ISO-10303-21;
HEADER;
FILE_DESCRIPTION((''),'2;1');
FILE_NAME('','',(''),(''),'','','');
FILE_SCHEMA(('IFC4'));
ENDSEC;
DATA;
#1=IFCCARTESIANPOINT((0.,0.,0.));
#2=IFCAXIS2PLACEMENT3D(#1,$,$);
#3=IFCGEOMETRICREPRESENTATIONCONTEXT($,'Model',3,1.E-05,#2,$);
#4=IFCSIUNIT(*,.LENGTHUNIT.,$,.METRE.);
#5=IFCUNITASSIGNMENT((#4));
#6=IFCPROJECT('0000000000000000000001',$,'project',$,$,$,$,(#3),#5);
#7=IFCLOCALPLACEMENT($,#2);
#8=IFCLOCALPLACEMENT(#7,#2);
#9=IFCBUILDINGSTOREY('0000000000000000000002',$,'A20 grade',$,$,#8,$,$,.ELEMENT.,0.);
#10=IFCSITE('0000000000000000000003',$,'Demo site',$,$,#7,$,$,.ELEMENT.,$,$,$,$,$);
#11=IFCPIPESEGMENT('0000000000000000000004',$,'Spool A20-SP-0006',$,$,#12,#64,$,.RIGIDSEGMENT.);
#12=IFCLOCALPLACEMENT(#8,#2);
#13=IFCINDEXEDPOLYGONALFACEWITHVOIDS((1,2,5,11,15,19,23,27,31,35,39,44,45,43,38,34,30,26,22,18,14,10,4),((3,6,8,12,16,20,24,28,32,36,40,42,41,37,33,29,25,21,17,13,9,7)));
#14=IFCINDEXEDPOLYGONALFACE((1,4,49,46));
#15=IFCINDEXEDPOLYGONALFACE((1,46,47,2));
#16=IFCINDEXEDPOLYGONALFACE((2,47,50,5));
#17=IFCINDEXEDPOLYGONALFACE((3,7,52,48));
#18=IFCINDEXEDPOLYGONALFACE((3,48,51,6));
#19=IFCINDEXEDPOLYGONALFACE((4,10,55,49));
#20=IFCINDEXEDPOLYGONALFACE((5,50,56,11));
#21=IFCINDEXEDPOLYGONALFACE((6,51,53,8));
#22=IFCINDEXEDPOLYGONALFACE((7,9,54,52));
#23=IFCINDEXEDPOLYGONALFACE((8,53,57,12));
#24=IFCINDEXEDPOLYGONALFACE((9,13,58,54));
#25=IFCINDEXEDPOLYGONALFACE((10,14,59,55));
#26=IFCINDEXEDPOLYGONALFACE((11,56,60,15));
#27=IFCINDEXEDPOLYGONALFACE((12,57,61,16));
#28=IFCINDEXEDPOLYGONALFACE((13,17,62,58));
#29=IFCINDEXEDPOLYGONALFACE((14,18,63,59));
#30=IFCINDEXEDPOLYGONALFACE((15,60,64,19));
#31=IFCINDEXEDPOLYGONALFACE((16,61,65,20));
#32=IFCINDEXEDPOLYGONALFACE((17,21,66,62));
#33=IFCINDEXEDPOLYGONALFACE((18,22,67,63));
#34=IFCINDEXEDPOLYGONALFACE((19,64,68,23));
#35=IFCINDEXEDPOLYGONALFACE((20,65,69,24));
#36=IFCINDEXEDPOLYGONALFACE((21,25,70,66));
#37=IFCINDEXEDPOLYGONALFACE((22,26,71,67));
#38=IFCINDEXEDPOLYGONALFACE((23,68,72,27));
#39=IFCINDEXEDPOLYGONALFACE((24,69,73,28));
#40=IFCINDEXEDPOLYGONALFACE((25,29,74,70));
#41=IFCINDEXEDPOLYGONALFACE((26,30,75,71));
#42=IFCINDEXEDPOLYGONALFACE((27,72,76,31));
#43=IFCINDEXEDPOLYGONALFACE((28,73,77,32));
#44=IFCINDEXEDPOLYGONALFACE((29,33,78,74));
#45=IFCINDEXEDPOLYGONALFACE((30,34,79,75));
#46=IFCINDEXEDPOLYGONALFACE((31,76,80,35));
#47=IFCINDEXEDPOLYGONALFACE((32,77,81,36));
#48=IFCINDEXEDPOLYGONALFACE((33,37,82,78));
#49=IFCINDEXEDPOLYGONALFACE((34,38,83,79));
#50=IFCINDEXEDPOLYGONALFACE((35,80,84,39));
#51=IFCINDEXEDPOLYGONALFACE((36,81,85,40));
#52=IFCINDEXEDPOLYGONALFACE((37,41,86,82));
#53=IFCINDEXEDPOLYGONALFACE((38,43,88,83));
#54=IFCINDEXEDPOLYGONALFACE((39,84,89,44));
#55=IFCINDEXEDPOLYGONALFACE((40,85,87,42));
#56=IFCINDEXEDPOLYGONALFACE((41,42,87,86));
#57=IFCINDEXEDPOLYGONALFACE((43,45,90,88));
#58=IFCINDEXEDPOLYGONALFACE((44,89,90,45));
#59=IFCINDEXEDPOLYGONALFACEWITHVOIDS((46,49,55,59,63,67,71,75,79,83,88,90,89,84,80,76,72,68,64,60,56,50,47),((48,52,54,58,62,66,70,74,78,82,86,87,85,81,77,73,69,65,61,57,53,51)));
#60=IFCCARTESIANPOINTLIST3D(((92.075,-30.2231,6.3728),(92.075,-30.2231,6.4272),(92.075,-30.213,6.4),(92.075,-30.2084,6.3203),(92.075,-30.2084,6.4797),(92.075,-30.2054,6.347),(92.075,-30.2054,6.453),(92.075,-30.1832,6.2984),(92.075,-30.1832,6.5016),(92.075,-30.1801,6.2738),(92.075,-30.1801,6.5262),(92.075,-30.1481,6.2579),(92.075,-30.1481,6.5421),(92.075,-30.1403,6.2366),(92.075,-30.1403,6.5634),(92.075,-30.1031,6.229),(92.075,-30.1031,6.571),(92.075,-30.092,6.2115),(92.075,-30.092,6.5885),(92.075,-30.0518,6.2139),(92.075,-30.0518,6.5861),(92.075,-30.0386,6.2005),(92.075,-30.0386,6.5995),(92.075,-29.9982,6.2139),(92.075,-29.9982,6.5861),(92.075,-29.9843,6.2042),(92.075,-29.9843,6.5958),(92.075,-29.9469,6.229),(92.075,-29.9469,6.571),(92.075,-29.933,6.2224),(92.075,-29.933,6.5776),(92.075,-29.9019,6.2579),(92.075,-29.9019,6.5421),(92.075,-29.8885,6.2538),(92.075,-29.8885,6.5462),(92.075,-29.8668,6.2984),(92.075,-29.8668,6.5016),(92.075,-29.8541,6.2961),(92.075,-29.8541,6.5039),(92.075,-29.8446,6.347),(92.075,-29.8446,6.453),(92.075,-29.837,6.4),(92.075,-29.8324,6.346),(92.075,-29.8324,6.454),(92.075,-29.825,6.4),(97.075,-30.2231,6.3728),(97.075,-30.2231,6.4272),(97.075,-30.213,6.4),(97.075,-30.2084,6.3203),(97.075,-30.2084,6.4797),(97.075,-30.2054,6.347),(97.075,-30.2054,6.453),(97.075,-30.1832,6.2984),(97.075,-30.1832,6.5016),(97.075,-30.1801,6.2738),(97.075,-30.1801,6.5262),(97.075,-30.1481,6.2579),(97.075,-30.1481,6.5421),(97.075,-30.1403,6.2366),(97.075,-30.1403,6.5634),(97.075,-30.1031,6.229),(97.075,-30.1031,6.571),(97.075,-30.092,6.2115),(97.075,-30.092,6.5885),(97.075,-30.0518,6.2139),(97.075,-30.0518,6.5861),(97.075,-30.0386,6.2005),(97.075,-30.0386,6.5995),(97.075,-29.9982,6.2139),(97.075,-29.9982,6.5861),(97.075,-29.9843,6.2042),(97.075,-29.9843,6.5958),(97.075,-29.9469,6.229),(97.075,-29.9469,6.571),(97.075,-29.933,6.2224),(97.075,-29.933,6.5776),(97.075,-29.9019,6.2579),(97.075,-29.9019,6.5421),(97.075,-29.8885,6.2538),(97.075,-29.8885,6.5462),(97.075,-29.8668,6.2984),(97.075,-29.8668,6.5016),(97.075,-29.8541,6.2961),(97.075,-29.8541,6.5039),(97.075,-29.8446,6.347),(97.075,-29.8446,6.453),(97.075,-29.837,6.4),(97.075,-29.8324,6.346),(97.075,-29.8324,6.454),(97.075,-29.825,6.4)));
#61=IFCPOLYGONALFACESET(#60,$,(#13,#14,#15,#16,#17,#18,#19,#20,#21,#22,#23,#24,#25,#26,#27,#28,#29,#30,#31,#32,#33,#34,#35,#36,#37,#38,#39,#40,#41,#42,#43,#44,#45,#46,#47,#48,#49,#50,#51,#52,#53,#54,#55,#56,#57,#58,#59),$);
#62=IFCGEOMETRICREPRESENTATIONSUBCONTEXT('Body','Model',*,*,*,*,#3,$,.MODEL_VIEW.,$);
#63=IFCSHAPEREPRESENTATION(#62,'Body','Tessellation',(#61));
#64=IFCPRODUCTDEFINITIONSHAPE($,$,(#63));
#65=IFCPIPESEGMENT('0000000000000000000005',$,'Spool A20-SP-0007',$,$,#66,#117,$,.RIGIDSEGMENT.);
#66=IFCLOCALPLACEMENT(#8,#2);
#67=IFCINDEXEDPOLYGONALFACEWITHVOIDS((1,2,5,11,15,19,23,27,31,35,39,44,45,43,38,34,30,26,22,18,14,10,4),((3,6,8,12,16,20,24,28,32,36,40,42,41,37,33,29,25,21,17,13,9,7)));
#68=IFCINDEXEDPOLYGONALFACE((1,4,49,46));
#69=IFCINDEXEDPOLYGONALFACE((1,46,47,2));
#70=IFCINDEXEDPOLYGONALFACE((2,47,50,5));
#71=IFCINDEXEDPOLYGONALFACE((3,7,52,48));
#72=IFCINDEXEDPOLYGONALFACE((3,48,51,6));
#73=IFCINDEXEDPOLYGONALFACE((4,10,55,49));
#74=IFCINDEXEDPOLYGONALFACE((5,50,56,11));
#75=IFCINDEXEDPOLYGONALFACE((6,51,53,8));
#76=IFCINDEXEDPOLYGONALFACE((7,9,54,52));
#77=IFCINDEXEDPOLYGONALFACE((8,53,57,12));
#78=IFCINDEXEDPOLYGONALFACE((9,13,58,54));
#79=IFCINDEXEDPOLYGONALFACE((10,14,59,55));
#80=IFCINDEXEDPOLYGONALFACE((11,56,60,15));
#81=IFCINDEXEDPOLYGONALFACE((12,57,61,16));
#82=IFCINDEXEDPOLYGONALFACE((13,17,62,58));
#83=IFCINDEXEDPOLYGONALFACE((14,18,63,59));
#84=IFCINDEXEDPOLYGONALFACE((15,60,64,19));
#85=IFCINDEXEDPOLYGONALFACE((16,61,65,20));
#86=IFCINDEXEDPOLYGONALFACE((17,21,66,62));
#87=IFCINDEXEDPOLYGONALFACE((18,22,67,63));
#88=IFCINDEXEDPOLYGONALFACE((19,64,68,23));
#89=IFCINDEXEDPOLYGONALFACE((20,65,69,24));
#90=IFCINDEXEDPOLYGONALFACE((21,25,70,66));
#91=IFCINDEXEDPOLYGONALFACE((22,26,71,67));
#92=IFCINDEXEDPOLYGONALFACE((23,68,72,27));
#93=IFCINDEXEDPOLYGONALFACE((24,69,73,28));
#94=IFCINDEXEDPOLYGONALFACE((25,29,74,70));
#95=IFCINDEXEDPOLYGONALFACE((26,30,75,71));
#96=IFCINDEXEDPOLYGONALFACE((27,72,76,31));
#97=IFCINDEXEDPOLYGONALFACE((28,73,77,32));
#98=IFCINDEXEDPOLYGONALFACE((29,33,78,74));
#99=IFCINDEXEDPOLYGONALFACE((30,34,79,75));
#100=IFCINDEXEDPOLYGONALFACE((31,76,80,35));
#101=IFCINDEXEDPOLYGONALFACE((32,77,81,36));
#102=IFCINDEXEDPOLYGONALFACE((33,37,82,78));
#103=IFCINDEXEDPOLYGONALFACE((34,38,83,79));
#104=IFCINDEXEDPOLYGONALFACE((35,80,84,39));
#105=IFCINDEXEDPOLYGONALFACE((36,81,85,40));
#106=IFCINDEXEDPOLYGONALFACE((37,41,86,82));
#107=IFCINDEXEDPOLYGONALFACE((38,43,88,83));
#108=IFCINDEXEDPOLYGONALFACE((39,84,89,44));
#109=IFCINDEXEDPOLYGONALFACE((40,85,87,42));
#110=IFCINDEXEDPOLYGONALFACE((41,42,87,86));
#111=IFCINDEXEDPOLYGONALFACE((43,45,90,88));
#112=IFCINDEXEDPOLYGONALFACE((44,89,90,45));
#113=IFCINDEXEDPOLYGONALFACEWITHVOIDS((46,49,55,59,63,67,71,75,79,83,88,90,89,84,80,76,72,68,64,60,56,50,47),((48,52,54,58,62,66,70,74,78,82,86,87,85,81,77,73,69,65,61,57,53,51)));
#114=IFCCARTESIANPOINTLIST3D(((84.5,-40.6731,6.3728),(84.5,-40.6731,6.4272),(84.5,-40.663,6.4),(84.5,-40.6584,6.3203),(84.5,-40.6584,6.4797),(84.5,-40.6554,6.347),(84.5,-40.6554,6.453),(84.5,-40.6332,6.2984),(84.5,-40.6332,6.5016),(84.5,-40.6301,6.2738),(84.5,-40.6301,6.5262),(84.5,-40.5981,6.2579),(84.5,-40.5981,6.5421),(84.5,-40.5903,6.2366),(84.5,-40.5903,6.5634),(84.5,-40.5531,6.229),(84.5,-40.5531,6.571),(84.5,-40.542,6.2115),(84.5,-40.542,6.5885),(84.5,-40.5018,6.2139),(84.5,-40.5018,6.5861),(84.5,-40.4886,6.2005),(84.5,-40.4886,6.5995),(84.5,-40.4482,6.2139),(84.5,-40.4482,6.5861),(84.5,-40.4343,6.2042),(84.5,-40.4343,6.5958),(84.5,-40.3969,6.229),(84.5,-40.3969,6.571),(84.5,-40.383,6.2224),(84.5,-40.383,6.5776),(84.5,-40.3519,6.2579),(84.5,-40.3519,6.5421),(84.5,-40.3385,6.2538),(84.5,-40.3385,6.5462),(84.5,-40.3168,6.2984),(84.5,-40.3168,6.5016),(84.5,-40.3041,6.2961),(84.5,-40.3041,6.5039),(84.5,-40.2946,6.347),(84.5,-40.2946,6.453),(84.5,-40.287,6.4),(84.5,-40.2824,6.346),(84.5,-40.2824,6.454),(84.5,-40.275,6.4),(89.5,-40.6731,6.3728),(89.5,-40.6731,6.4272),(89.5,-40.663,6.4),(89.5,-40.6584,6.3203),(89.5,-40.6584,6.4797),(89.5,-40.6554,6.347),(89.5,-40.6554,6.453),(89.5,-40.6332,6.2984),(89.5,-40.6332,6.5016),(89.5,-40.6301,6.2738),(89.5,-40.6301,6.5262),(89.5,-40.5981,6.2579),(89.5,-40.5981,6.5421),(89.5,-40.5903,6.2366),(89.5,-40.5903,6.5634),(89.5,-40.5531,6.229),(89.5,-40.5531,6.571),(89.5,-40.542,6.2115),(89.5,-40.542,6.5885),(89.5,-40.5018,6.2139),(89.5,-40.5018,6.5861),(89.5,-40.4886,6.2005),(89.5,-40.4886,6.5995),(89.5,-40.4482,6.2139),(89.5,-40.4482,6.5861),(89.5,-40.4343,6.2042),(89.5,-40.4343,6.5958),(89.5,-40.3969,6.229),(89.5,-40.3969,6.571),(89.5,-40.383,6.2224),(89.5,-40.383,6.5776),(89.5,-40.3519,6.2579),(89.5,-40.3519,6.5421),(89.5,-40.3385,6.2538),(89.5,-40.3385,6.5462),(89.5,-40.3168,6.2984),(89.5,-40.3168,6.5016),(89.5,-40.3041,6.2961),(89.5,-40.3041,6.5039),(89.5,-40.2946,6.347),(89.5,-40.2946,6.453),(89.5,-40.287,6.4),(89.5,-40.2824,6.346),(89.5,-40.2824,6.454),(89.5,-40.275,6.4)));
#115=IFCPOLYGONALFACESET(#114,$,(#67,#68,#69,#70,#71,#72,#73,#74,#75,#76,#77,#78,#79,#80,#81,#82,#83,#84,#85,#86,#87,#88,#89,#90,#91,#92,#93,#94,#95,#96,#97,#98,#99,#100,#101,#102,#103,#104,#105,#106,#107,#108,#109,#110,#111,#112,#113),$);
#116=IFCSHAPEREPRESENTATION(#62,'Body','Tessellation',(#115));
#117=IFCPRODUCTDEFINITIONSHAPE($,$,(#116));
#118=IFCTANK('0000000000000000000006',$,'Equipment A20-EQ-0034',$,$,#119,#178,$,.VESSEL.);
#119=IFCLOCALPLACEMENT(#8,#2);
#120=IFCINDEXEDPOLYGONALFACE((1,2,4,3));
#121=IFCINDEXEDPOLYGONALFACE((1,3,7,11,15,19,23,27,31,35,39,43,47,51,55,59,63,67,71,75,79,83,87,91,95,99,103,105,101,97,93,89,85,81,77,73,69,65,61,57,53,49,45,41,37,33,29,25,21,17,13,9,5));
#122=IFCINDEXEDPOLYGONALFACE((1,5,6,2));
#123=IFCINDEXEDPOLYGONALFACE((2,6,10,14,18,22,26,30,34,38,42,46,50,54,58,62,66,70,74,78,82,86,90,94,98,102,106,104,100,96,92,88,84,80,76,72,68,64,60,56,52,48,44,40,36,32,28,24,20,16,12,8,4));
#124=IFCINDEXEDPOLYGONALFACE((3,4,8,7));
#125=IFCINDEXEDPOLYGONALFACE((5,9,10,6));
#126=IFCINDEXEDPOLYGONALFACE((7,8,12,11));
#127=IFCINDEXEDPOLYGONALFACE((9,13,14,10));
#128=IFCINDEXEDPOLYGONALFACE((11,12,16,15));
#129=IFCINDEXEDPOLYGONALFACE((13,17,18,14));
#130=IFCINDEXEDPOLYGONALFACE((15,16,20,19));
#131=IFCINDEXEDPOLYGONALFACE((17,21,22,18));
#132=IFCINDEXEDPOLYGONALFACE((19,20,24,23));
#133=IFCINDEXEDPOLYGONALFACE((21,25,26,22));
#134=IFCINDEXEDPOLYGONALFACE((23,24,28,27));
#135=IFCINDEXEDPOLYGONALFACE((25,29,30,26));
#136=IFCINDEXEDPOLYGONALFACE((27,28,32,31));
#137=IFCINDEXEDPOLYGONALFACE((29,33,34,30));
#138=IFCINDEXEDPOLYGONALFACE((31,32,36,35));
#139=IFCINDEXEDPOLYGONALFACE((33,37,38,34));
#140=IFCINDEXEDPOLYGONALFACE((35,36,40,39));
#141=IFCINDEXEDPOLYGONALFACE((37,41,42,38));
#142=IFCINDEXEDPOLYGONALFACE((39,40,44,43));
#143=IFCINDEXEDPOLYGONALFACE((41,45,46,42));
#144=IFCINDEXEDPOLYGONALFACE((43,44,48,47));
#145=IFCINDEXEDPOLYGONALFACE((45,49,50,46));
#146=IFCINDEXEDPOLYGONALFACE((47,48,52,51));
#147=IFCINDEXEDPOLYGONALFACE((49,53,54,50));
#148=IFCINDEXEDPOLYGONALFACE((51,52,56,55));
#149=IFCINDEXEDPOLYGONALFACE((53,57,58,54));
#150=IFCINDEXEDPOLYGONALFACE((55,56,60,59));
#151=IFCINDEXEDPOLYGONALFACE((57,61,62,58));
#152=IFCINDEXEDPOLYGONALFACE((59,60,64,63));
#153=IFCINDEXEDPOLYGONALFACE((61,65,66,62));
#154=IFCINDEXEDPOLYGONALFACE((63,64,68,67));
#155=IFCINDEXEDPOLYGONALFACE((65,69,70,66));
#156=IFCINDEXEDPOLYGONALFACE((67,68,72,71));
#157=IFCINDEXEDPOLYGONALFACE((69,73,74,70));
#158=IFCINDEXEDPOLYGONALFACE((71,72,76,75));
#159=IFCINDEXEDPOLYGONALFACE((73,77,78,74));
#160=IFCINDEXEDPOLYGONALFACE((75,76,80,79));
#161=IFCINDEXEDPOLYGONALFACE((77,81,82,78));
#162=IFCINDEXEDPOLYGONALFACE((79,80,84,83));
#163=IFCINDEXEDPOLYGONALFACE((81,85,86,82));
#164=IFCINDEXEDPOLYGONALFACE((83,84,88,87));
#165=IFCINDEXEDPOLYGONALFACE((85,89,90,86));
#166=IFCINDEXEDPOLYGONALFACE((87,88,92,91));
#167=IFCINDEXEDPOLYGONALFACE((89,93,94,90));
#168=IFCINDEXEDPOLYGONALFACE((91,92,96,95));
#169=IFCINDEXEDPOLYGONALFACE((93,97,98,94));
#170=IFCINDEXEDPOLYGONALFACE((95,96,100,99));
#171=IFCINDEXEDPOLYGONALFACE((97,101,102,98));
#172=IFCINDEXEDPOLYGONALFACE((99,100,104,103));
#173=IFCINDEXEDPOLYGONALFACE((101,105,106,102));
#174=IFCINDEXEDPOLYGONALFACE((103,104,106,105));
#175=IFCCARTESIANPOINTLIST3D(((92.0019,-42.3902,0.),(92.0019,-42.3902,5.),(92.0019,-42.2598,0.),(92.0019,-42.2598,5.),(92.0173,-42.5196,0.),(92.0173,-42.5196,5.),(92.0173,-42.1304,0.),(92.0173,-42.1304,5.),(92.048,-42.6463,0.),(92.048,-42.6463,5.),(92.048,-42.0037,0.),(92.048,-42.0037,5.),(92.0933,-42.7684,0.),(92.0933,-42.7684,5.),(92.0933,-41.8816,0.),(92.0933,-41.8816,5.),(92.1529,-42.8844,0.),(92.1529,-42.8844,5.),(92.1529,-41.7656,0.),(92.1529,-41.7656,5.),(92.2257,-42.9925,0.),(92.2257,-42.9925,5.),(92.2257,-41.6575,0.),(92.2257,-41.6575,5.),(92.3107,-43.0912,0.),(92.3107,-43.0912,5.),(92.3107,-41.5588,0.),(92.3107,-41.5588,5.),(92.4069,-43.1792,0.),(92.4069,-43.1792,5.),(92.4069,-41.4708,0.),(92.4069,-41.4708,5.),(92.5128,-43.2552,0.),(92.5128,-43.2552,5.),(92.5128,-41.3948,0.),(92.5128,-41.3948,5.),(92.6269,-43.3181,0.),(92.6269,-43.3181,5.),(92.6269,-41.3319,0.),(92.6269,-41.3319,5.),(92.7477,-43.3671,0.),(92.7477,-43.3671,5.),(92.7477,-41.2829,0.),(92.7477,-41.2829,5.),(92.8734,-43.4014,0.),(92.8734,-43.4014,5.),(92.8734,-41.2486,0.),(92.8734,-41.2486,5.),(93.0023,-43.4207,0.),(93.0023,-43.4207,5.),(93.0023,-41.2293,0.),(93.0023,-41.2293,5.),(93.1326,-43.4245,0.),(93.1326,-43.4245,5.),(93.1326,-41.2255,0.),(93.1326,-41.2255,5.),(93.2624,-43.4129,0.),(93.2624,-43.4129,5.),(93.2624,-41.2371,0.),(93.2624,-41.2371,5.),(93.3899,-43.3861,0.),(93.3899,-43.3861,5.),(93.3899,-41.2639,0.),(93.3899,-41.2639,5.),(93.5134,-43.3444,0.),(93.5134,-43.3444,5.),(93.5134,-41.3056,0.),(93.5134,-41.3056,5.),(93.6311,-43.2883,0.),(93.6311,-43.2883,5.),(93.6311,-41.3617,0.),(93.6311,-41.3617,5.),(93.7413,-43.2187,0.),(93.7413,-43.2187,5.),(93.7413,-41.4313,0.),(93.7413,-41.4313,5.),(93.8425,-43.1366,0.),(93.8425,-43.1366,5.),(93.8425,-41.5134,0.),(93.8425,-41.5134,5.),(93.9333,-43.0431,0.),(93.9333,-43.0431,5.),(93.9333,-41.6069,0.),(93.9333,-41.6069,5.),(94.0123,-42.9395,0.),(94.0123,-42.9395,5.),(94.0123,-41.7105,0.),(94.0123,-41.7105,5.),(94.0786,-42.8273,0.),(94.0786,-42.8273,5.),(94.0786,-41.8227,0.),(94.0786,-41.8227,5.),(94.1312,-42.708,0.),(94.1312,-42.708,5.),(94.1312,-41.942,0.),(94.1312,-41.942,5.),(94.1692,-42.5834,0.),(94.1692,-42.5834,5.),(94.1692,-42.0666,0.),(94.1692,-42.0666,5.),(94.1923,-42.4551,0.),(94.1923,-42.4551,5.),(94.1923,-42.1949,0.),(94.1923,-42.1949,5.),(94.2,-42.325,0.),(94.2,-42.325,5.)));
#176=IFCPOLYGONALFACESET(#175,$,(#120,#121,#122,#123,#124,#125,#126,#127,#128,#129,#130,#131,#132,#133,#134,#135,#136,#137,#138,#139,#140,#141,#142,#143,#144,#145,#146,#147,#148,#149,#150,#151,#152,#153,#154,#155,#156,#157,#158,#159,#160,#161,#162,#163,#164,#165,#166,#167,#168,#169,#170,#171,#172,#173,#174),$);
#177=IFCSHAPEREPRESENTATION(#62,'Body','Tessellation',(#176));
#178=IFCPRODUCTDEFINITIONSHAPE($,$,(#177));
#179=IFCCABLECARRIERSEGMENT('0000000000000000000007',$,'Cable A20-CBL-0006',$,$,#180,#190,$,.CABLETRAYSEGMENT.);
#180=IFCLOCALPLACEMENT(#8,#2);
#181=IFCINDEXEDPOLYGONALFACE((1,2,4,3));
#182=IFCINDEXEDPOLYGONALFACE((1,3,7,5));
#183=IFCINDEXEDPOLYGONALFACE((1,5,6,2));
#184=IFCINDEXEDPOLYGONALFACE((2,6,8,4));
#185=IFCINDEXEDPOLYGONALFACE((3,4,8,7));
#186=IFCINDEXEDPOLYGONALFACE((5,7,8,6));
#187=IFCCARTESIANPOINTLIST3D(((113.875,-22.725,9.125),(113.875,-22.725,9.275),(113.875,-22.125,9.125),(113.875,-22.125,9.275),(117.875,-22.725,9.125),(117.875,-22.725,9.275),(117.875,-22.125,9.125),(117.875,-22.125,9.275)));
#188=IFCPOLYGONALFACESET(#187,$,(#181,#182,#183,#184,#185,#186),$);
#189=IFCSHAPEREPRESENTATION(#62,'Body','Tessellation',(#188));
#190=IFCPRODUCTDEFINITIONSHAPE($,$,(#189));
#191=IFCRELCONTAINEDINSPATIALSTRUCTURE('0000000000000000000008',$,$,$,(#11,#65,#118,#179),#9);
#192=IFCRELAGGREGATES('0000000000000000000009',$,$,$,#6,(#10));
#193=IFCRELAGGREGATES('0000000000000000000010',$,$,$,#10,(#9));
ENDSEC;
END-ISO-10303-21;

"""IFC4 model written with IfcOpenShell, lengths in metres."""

from ifc_helpers import new_model, si_unit, frame, origin, place, context, subcontext, project, spatial, rectangle, circle, hollow_circle, extrude, element, save


model = new_model("IFC4")

# Units and contexts
model_context = context("Model", 3, precision=1e-05, world=origin())
body_context = subcontext(model_context, "Body", "Model", "MODEL_VIEW")
ifc_project = project(units=[si_unit("LENGTHUNIT", "METRE")], contexts=[model_context])

# Site, storey
site_placement = place(None, origin())
site = spatial("IfcSite", under=ifc_project, at=site_placement, Name="Demo site", CompositionType="ELEMENT")
storey_placement = place(site_placement, origin())
storey = spatial("IfcBuildingStorey", under=site, at=storey_placement, Name="A20 grade", CompositionType="ELEMENT", Elevation=0.0)

# Pipe segments
for number, where, name in (
    (1, (92.075, -30.025, 6.4), "Spool A20-SP-0006"),
    (2, (84.5, -40.475, 6.4), "Spool A20-SP-0007"),
):
    element("IfcPipeSegment", number, at=place(storey_placement, frame(where)), inside=storey, Name=name, PredefinedType="RIGIDSEGMENT", context=body_context, shape_type="SweptSolid", body=[
        extrude(hollow_circle(Radius=0.2, WallThickness=0.012), frame((0.0, 0.0, 0.0), z_axis=(1.0, 0.0, 0.0), x_axis=(0.0, 1.0, 0.0)), (0.0, 0.0, 1.0), 5.0),
    ])

# Tank
tank_placement = place(storey_placement, frame((93.1, -42.325, 0.0)))
element("IfcTank", 3, at=tank_placement, inside=storey, Name="Equipment A20-EQ-0034", PredefinedType="VESSEL", context=body_context, shape_type="SweptSolid", body=[
    extrude(circle(Radius=1.1), origin(), (0.0, 0.0, 1.0), 5.0),
])

# Cable carrier segment
cable_carrier_segment_1_placement = place(storey_placement, frame((113.875, -22.425, 9.2)))
element("IfcCableCarrierSegment", 4, at=cable_carrier_segment_1_placement, inside=storey, Name="Cable A20-CBL-0006", PredefinedType="CABLETRAYSEGMENT", context=body_context, shape_type="SweptSolid", body=[
    extrude(rectangle(XDim=0.6, YDim=0.15), frame((0.0, 0.0, 0.0), z_axis=(1.0, 0.0, 0.0), x_axis=(0.0, 1.0, 0.0)), (0.0, 0.0, 1.0), 4.0),
])

save(model, "model.ifc")
